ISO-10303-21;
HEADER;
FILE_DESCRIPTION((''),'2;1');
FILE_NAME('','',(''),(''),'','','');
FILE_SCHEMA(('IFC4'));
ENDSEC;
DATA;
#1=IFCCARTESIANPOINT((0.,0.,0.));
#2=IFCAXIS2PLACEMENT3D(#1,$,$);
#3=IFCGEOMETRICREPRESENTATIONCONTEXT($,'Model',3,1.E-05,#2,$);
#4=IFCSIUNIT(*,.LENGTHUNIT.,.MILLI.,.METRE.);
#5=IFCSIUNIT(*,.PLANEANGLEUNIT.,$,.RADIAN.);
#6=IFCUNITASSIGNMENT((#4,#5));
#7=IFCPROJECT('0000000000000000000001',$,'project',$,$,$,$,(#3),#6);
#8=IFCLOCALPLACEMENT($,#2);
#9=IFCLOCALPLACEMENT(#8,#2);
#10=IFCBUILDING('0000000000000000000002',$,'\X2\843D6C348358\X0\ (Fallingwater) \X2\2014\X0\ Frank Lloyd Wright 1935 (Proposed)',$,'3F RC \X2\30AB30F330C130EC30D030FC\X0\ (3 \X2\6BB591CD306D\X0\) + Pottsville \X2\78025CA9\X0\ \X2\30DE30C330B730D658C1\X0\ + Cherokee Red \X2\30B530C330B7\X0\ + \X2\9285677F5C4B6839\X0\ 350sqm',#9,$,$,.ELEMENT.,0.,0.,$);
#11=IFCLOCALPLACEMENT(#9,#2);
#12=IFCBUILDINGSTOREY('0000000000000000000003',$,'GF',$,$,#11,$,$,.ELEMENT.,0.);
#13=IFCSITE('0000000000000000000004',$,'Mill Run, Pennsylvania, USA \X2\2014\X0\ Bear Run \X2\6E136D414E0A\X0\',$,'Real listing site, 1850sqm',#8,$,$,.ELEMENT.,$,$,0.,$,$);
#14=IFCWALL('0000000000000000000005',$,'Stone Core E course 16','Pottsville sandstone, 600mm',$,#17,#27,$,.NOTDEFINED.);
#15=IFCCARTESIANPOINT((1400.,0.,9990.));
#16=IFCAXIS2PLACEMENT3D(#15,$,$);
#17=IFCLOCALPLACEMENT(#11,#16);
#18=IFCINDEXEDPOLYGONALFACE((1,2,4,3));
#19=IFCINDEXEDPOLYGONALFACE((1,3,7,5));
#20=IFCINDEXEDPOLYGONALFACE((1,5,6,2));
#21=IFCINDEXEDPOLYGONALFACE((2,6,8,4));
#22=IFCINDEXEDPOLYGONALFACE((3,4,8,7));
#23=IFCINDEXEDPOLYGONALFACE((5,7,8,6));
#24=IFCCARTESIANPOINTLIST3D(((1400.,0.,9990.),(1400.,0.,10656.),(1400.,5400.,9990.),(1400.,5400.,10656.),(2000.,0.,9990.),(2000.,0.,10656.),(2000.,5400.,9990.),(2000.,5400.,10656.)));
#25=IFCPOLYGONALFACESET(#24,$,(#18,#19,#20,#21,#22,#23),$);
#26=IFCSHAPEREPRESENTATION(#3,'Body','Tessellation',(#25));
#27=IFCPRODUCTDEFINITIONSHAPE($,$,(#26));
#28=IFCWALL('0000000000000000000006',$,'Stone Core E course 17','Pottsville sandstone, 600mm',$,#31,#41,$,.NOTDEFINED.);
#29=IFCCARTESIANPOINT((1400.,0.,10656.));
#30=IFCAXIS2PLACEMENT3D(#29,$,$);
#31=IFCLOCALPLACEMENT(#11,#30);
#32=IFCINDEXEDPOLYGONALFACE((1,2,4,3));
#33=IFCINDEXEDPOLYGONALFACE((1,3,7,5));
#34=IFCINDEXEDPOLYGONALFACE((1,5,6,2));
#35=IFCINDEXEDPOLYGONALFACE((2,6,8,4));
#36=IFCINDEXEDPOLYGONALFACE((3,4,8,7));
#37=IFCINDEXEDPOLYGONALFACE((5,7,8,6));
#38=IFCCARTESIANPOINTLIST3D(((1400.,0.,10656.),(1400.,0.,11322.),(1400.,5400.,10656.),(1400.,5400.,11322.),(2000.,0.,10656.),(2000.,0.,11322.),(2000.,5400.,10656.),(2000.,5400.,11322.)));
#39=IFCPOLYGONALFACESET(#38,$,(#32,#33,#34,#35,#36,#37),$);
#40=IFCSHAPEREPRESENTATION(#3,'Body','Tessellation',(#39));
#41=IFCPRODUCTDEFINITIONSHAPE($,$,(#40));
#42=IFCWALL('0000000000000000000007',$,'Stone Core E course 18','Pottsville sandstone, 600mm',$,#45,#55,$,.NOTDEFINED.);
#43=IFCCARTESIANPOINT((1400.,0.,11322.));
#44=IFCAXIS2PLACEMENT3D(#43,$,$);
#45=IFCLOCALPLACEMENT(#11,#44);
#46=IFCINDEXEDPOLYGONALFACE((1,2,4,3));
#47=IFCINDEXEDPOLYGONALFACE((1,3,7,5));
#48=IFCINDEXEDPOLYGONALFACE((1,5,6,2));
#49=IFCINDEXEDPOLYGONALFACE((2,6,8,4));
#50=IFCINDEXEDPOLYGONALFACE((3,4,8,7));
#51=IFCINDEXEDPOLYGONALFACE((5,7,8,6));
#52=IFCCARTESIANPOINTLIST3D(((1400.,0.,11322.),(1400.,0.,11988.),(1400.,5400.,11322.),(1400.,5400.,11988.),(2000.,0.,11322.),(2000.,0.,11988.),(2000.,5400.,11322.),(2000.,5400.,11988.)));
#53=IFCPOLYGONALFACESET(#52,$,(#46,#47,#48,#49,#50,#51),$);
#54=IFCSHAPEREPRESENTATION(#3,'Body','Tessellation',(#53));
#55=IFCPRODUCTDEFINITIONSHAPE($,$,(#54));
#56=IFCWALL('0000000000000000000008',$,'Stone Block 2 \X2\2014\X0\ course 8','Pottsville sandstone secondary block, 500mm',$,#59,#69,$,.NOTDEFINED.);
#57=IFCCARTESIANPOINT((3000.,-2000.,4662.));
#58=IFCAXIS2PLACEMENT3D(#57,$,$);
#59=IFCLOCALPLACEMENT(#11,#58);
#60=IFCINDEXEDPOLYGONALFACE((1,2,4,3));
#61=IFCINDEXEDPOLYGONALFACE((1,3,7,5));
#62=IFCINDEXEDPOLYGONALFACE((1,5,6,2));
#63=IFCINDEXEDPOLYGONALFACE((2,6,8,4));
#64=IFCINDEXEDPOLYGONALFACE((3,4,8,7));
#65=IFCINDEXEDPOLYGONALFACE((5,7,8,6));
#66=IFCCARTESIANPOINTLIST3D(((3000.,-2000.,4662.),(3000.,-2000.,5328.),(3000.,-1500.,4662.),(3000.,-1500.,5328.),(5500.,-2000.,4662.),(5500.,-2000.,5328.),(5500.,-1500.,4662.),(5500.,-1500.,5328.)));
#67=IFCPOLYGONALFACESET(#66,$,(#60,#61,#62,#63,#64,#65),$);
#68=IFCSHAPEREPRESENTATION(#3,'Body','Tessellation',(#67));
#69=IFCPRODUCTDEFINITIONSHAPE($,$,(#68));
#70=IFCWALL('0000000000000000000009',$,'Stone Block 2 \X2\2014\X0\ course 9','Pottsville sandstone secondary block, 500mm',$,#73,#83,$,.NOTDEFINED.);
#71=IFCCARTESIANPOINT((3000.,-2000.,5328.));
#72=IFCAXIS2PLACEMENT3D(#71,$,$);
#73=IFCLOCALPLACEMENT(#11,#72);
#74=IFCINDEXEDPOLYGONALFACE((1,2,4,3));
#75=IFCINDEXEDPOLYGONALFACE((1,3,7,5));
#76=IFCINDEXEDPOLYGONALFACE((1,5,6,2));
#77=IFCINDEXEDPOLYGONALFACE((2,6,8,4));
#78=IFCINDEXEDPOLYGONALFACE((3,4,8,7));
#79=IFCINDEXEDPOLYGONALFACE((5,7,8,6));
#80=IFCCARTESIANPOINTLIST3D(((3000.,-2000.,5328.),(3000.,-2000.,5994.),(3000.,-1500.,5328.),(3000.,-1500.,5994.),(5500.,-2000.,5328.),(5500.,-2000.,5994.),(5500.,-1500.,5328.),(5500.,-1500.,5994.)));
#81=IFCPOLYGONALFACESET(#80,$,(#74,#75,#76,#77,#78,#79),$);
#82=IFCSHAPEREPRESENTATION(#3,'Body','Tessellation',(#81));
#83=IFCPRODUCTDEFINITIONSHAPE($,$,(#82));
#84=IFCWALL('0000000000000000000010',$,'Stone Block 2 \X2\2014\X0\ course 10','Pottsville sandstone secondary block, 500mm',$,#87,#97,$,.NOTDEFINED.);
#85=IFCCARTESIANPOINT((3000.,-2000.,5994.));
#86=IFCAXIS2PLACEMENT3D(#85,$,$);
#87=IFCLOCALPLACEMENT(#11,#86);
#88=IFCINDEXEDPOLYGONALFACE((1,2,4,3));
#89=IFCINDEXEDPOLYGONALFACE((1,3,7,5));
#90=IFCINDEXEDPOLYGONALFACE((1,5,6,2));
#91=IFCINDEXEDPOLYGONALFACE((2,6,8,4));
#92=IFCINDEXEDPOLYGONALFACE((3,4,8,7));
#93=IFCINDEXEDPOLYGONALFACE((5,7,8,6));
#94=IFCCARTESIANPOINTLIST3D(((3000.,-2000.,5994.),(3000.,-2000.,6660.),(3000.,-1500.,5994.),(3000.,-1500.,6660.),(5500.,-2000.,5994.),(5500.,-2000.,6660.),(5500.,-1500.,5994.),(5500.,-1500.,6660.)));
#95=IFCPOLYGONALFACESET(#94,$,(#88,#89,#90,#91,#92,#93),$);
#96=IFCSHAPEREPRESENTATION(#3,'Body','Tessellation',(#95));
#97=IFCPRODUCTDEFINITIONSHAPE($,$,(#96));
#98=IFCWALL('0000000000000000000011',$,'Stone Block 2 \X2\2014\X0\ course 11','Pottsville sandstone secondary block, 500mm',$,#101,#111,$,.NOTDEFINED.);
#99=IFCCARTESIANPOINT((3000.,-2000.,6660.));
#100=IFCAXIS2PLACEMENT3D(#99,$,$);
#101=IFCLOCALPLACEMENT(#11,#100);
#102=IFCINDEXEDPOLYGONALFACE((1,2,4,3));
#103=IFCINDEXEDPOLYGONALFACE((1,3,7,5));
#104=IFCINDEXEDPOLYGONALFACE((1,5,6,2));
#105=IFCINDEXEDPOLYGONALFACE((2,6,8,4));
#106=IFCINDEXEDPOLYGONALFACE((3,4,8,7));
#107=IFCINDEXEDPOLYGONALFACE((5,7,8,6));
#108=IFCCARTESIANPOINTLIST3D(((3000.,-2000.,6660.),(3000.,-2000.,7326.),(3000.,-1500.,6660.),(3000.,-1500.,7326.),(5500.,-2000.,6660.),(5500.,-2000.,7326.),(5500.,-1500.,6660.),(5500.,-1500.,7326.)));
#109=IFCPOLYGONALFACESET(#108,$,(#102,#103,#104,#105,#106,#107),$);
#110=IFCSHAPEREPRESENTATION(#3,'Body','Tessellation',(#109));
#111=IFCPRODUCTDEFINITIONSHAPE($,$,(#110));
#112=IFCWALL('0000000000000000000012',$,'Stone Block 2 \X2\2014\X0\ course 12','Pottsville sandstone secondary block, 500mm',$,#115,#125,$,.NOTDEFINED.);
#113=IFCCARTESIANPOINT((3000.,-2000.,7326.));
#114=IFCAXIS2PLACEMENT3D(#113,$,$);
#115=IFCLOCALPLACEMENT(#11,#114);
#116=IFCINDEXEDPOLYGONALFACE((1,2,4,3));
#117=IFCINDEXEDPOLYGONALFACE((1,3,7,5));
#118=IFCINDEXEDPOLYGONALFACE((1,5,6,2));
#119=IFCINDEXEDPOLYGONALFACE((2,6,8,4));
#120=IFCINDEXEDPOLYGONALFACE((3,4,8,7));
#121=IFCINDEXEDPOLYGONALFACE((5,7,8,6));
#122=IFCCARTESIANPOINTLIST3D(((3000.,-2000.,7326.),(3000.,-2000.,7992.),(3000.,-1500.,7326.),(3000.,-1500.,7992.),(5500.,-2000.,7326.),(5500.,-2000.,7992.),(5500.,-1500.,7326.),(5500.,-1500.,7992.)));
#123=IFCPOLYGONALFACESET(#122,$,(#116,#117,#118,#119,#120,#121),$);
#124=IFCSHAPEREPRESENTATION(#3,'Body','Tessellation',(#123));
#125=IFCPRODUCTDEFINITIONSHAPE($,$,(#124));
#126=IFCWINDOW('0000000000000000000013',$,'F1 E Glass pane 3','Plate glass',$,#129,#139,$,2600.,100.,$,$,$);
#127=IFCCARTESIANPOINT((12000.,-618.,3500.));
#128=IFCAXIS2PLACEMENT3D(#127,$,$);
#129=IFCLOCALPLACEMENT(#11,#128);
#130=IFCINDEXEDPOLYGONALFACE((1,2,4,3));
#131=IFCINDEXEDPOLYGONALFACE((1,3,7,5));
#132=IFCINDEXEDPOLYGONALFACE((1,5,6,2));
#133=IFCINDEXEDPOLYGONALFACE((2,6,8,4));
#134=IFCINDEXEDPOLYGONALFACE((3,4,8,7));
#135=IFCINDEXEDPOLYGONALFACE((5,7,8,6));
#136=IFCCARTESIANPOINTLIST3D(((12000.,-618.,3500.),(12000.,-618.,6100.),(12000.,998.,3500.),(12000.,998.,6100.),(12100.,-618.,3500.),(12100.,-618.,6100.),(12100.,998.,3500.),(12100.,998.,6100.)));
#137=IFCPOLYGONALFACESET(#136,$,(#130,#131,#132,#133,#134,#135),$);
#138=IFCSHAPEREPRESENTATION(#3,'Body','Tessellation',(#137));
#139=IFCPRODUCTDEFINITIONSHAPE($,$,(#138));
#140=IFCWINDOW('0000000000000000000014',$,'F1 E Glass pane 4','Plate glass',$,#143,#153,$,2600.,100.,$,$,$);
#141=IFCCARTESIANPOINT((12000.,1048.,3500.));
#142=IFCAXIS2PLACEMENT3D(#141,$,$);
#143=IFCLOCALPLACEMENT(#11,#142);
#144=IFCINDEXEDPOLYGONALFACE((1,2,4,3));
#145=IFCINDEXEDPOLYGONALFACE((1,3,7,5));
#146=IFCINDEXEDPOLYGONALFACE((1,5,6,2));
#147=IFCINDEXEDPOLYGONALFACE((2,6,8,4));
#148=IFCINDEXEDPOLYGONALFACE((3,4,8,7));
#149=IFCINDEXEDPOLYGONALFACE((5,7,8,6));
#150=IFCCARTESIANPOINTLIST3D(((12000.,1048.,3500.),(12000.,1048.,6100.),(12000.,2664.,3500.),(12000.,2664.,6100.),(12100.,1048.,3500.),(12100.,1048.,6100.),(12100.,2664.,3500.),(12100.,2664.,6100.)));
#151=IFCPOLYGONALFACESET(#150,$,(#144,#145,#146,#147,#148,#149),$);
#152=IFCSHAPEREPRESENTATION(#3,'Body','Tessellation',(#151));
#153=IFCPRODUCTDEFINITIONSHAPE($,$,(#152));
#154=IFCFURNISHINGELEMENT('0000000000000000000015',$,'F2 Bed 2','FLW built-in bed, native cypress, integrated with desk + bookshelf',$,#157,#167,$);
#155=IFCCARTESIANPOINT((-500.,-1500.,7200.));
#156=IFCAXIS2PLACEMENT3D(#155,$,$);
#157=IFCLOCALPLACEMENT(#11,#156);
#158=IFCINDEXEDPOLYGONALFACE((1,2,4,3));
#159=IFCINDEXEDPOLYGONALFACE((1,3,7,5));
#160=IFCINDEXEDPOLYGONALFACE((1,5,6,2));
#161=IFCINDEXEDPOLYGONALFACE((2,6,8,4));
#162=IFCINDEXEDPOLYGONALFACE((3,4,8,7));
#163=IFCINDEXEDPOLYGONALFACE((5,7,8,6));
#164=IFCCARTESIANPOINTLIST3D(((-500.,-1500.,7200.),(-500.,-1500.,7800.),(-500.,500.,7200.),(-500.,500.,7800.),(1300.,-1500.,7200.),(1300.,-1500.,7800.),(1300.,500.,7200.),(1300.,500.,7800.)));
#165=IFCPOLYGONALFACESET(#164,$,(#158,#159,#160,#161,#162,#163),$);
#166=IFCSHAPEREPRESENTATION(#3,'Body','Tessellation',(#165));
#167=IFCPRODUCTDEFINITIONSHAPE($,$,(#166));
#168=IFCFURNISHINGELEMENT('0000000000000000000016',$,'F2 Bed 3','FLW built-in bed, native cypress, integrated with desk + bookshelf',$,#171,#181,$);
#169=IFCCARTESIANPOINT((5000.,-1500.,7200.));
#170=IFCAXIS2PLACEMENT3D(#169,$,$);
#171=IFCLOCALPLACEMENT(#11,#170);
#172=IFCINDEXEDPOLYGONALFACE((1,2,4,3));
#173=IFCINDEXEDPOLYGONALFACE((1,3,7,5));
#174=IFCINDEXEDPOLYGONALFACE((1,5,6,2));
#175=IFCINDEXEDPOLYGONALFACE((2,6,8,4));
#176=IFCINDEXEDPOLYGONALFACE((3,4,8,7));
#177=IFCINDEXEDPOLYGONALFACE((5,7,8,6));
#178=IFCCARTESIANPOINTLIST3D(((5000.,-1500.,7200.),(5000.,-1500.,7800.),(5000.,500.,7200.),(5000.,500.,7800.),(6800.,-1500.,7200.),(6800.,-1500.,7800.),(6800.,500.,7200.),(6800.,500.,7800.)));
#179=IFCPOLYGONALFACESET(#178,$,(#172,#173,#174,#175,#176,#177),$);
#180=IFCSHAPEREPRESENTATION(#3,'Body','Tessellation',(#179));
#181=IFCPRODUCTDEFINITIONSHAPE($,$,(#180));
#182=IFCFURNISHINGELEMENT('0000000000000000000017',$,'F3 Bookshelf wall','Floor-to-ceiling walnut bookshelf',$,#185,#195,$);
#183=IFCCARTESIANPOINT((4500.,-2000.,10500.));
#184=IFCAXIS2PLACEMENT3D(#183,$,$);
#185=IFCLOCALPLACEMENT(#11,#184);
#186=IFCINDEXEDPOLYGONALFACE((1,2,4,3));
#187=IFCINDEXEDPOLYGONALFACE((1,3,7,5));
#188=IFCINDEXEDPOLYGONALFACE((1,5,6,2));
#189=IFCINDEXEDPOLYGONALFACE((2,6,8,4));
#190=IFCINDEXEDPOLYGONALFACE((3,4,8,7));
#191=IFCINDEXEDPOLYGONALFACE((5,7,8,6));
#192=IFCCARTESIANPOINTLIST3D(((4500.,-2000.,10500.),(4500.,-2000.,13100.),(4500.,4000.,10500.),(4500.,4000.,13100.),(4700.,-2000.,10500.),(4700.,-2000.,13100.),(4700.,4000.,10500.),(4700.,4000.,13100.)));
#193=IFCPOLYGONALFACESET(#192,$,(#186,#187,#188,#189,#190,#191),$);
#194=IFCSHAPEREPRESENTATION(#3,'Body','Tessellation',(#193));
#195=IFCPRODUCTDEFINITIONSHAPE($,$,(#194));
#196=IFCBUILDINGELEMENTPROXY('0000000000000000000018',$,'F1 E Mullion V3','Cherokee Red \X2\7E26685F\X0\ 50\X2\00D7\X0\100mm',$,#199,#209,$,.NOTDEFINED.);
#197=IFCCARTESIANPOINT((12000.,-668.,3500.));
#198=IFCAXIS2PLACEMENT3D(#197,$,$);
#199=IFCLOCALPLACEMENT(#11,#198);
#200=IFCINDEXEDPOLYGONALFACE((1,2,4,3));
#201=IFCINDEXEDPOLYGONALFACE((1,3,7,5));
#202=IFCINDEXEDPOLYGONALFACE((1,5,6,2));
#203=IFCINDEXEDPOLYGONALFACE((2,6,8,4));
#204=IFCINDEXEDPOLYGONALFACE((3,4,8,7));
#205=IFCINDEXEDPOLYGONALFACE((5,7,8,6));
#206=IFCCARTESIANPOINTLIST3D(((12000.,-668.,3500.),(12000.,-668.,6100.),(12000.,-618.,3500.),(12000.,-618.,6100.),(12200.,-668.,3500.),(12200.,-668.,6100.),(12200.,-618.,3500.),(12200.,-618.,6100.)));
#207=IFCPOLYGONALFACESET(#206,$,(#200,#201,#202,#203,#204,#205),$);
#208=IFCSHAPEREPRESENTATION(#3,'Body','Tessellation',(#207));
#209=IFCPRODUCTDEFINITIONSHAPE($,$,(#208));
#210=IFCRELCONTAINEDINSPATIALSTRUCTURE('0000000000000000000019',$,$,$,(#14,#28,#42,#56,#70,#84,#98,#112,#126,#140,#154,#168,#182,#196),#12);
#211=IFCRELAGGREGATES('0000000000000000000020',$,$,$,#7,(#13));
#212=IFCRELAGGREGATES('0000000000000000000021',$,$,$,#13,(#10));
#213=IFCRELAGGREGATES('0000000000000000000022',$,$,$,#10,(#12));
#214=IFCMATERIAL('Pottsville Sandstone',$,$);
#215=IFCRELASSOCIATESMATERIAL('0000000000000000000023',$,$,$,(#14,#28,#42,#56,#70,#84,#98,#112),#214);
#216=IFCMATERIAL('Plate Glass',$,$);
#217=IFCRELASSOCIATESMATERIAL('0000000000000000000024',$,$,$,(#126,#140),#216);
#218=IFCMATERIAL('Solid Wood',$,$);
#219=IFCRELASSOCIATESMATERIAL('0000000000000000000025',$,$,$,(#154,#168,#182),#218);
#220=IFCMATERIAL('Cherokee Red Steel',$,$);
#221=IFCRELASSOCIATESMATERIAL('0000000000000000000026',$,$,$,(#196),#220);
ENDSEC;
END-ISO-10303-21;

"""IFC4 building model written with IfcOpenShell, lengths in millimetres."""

from ifc_helpers import new_model, si_unit, frame, frame_2d, origin, place, context, project, spatial, rectangle, extrude, material, element, save


model = new_model("IFC4")

# Units and contexts
model_context = context("Model", 3, precision=1e-05, world=origin())
ifc_project = project(units=[si_unit("LENGTHUNIT", "METRE", prefix="MILLI"), si_unit("PLANEANGLEUNIT", "RADIAN")], contexts=[model_context])

# Site, building, storey
site_placement = place(None, origin())
site = spatial("IfcSite", under=ifc_project, at=site_placement, Name="Mill Run, Pennsylvania, USA — Bear Run 渓流上", ObjectType="Real listing site, 1850sqm", CompositionType="ELEMENT", RefElevation=0.0)
building_placement = place(site_placement, origin())
building = spatial("IfcBuilding", under=site, at=building_placement, Name="落水荘 (Fallingwater) — Frank Lloyd Wright 1935 (Proposed)", ObjectType="3F RC カンチレバー (3 段重ね) + Pottsville 砂岩 マッシブ壁 + Cherokee Red サッシ + 銅板屋根 350sqm", CompositionType="ELEMENT", ElevationOfRefHeight=0.0, ElevationOfTerrain=0.0)
storey_placement = place(building_placement, origin())
storey = spatial("IfcBuildingStorey", under=building, at=storey_placement, Name="GF", CompositionType="ELEMENT", Elevation=0.0)

# Walls
ifc_material_1 = material(Name="Pottsville Sandstone")
wall_1_placement = place(storey_placement, frame((1400.0, 0.0, 9990.0)))
element("IfcWall", 1, at=wall_1_placement, inside=storey, material=ifc_material_1, Name="Stone Core E course 16", Description="Pottsville sandstone, 600mm", PredefinedType="NOTDEFINED", context=model_context, shape_type="SweptSolid", body=[
    extrude(rectangle(XDim=600.0, YDim=5400.0, at=frame_2d((300.0, 2700.0))), frame((1400.0, 0.0, 9990.0)), (0.0, 0.0, 1.0), 666.0),
])
wall_2_placement = place(storey_placement, frame((1400.0, 0.0, 10656.0)))
element("IfcWall", 2, at=wall_2_placement, inside=storey, material=ifc_material_1, Name="Stone Core E course 17", Description="Pottsville sandstone, 600mm", PredefinedType="NOTDEFINED", context=model_context, shape_type="SweptSolid", body=[
    extrude(rectangle(XDim=600.0, YDim=5400.0, at=frame_2d((300.0, 2700.0))), frame((1400.0, 0.0, 10656.0)), (0.0, 0.0, 1.0), 666.0),
])
wall_3_placement = place(storey_placement, frame((1400.0, 0.0, 11322.0)))
element("IfcWall", 3, at=wall_3_placement, inside=storey, material=ifc_material_1, Name="Stone Core E course 18", Description="Pottsville sandstone, 600mm", PredefinedType="NOTDEFINED", context=model_context, shape_type="SweptSolid", body=[
    extrude(rectangle(XDim=600.0, YDim=5400.0, at=frame_2d((300.0, 2700.0))), frame((1400.0, 0.0, 11322.0)), (0.0, 0.0, 1.0), 666.0),
])
wall_4_placement = place(storey_placement, frame((3000.0, -2000.0, 4662.0)))
element("IfcWall", 4, at=wall_4_placement, inside=storey, material=ifc_material_1, Name="Stone Block 2 — course 8", Description="Pottsville sandstone secondary block, 500mm", PredefinedType="NOTDEFINED", context=model_context, shape_type="SweptSolid", body=[
    extrude(rectangle(XDim=2500.0, YDim=500.0, at=frame_2d((1250.0, 250.0))), frame((3000.0, -2000.0, 4662.0)), (0.0, 0.0, 1.0), 666.0),
])
wall_5_placement = place(storey_placement, frame((3000.0, -2000.0, 5328.0)))
element("IfcWall", 5, at=wall_5_placement, inside=storey, material=ifc_material_1, Name="Stone Block 2 — course 9", Description="Pottsville sandstone secondary block, 500mm", PredefinedType="NOTDEFINED", context=model_context, shape_type="SweptSolid", body=[
    extrude(rectangle(XDim=2500.0, YDim=500.0, at=frame_2d((1250.0, 250.0))), frame((3000.0, -2000.0, 5328.0)), (0.0, 0.0, 1.0), 666.0),
])
wall_6_placement = place(storey_placement, frame((3000.0, -2000.0, 5994.0)))
element("IfcWall", 6, at=wall_6_placement, inside=storey, material=ifc_material_1, Name="Stone Block 2 — course 10", Description="Pottsville sandstone secondary block, 500mm", PredefinedType="NOTDEFINED", context=model_context, shape_type="SweptSolid", body=[
    extrude(rectangle(XDim=2500.0, YDim=500.0, at=frame_2d((1250.0, 250.0))), frame((3000.0, -2000.0, 5994.0)), (0.0, 0.0, 1.0), 666.0),
])
wall_7_placement = place(storey_placement, frame((3000.0, -2000.0, 6660.0)))
element("IfcWall", 7, at=wall_7_placement, inside=storey, material=ifc_material_1, Name="Stone Block 2 — course 11", Description="Pottsville sandstone secondary block, 500mm", PredefinedType="NOTDEFINED", context=model_context, shape_type="SweptSolid", body=[
    extrude(rectangle(XDim=2500.0, YDim=500.0, at=frame_2d((1250.0, 250.0))), frame((3000.0, -2000.0, 6660.0)), (0.0, 0.0, 1.0), 666.0),
])
wall_8_placement = place(storey_placement, frame((3000.0, -2000.0, 7326.0)))
element("IfcWall", 8, at=wall_8_placement, inside=storey, material=ifc_material_1, Name="Stone Block 2 — course 12", Description="Pottsville sandstone secondary block, 500mm", PredefinedType="NOTDEFINED", context=model_context, shape_type="SweptSolid", body=[
    extrude(rectangle(XDim=2500.0, YDim=500.0, at=frame_2d((1250.0, 250.0))), frame((3000.0, -2000.0, 7326.0)), (0.0, 0.0, 1.0), 666.0),
])

# Windows
ifc_material_2 = material(Name="Plate Glass")
window_1_placement = place(storey_placement, frame((12000.0, -618.0, 3500.0)))
element("IfcWindow", 9, at=window_1_placement, inside=storey, material=ifc_material_2, Name="F1 E Glass pane 3", Description="Plate glass", OverallHeight=2600.0, OverallWidth=100.0, context=model_context, shape_type="SweptSolid", body=[
    extrude(rectangle(XDim=100.0, YDim=1616.0, at=frame_2d((50.0, 808.0))), frame((12000.0, -618.0, 3500.0)), (0.0, 0.0, 1.0), 2600.0),
])
window_2_placement = place(storey_placement, frame((12000.0, 1048.0, 3500.0)))
element("IfcWindow", 10, at=window_2_placement, inside=storey, material=ifc_material_2, Name="F1 E Glass pane 4", Description="Plate glass", OverallHeight=2600.0, OverallWidth=100.0, context=model_context, shape_type="SweptSolid", body=[
    extrude(rectangle(XDim=100.0, YDim=1616.0, at=frame_2d((50.0, 808.0))), frame((12000.0, 1048.0, 3500.0)), (0.0, 0.0, 1.0), 2600.0),
])

# Furnishing elements
ifc_material_3 = material(Name="Solid Wood")
furnishing_1_placement = place(storey_placement, frame((-500.0, -1500.0, 7200.0)))
element("IfcFurnishingElement", 11, at=furnishing_1_placement, inside=storey, material=ifc_material_3, Name="F2 Bed 2", Description="FLW built-in bed, native cypress, integrated with desk + bookshelf", context=model_context, shape_type="SweptSolid", body=[
    extrude(rectangle(XDim=1800.0, YDim=2000.0, at=frame_2d((900.0, 1000.0))), frame((-500.0, -1500.0, 7200.0)), (0.0, 0.0, 1.0), 600.0),
])
furnishing_2_placement = place(storey_placement, frame((5000.0, -1500.0, 7200.0)))
element("IfcFurnishingElement", 12, at=furnishing_2_placement, inside=storey, material=ifc_material_3, Name="F2 Bed 3", Description="FLW built-in bed, native cypress, integrated with desk + bookshelf", context=model_context, shape_type="SweptSolid", body=[
    extrude(rectangle(XDim=1800.0, YDim=2000.0, at=frame_2d((900.0, 1000.0))), frame((5000.0, -1500.0, 7200.0)), (0.0, 0.0, 1.0), 600.0),
])
furnishing_3_placement = place(storey_placement, frame((4500.0, -2000.0, 10500.0)))
element("IfcFurnishingElement", 13, at=furnishing_3_placement, inside=storey, material=ifc_material_3, Name="F3 Bookshelf wall", Description="Floor-to-ceiling walnut bookshelf", context=model_context, shape_type="SweptSolid", body=[
    extrude(rectangle(XDim=200.0, YDim=6000.0, at=frame_2d((100.0, 3000.0))), frame((4500.0, -2000.0, 10500.0)), (0.0, 0.0, 1.0), 2600.0),
])

# Building element proxy
ifc_material_4 = material(Name="Cherokee Red Steel")
proxy_1_placement = place(storey_placement, frame((12000.0, -668.0, 3500.0)))
element("IfcBuildingElementProxy", 14, at=proxy_1_placement, inside=storey, material=ifc_material_4, Name="F1 E Mullion V3", Description="Cherokee Red 縦桟 50×100mm", PredefinedType="NOTDEFINED", context=model_context, shape_type="SweptSolid", body=[
    extrude(rectangle(XDim=200.0, YDim=50.0, at=frame_2d((100.0, 25.0))), frame((12000.0, -668.0, 3500.0)), (0.0, 0.0, 1.0), 2600.0),
])

save(model, "model.ifc")
